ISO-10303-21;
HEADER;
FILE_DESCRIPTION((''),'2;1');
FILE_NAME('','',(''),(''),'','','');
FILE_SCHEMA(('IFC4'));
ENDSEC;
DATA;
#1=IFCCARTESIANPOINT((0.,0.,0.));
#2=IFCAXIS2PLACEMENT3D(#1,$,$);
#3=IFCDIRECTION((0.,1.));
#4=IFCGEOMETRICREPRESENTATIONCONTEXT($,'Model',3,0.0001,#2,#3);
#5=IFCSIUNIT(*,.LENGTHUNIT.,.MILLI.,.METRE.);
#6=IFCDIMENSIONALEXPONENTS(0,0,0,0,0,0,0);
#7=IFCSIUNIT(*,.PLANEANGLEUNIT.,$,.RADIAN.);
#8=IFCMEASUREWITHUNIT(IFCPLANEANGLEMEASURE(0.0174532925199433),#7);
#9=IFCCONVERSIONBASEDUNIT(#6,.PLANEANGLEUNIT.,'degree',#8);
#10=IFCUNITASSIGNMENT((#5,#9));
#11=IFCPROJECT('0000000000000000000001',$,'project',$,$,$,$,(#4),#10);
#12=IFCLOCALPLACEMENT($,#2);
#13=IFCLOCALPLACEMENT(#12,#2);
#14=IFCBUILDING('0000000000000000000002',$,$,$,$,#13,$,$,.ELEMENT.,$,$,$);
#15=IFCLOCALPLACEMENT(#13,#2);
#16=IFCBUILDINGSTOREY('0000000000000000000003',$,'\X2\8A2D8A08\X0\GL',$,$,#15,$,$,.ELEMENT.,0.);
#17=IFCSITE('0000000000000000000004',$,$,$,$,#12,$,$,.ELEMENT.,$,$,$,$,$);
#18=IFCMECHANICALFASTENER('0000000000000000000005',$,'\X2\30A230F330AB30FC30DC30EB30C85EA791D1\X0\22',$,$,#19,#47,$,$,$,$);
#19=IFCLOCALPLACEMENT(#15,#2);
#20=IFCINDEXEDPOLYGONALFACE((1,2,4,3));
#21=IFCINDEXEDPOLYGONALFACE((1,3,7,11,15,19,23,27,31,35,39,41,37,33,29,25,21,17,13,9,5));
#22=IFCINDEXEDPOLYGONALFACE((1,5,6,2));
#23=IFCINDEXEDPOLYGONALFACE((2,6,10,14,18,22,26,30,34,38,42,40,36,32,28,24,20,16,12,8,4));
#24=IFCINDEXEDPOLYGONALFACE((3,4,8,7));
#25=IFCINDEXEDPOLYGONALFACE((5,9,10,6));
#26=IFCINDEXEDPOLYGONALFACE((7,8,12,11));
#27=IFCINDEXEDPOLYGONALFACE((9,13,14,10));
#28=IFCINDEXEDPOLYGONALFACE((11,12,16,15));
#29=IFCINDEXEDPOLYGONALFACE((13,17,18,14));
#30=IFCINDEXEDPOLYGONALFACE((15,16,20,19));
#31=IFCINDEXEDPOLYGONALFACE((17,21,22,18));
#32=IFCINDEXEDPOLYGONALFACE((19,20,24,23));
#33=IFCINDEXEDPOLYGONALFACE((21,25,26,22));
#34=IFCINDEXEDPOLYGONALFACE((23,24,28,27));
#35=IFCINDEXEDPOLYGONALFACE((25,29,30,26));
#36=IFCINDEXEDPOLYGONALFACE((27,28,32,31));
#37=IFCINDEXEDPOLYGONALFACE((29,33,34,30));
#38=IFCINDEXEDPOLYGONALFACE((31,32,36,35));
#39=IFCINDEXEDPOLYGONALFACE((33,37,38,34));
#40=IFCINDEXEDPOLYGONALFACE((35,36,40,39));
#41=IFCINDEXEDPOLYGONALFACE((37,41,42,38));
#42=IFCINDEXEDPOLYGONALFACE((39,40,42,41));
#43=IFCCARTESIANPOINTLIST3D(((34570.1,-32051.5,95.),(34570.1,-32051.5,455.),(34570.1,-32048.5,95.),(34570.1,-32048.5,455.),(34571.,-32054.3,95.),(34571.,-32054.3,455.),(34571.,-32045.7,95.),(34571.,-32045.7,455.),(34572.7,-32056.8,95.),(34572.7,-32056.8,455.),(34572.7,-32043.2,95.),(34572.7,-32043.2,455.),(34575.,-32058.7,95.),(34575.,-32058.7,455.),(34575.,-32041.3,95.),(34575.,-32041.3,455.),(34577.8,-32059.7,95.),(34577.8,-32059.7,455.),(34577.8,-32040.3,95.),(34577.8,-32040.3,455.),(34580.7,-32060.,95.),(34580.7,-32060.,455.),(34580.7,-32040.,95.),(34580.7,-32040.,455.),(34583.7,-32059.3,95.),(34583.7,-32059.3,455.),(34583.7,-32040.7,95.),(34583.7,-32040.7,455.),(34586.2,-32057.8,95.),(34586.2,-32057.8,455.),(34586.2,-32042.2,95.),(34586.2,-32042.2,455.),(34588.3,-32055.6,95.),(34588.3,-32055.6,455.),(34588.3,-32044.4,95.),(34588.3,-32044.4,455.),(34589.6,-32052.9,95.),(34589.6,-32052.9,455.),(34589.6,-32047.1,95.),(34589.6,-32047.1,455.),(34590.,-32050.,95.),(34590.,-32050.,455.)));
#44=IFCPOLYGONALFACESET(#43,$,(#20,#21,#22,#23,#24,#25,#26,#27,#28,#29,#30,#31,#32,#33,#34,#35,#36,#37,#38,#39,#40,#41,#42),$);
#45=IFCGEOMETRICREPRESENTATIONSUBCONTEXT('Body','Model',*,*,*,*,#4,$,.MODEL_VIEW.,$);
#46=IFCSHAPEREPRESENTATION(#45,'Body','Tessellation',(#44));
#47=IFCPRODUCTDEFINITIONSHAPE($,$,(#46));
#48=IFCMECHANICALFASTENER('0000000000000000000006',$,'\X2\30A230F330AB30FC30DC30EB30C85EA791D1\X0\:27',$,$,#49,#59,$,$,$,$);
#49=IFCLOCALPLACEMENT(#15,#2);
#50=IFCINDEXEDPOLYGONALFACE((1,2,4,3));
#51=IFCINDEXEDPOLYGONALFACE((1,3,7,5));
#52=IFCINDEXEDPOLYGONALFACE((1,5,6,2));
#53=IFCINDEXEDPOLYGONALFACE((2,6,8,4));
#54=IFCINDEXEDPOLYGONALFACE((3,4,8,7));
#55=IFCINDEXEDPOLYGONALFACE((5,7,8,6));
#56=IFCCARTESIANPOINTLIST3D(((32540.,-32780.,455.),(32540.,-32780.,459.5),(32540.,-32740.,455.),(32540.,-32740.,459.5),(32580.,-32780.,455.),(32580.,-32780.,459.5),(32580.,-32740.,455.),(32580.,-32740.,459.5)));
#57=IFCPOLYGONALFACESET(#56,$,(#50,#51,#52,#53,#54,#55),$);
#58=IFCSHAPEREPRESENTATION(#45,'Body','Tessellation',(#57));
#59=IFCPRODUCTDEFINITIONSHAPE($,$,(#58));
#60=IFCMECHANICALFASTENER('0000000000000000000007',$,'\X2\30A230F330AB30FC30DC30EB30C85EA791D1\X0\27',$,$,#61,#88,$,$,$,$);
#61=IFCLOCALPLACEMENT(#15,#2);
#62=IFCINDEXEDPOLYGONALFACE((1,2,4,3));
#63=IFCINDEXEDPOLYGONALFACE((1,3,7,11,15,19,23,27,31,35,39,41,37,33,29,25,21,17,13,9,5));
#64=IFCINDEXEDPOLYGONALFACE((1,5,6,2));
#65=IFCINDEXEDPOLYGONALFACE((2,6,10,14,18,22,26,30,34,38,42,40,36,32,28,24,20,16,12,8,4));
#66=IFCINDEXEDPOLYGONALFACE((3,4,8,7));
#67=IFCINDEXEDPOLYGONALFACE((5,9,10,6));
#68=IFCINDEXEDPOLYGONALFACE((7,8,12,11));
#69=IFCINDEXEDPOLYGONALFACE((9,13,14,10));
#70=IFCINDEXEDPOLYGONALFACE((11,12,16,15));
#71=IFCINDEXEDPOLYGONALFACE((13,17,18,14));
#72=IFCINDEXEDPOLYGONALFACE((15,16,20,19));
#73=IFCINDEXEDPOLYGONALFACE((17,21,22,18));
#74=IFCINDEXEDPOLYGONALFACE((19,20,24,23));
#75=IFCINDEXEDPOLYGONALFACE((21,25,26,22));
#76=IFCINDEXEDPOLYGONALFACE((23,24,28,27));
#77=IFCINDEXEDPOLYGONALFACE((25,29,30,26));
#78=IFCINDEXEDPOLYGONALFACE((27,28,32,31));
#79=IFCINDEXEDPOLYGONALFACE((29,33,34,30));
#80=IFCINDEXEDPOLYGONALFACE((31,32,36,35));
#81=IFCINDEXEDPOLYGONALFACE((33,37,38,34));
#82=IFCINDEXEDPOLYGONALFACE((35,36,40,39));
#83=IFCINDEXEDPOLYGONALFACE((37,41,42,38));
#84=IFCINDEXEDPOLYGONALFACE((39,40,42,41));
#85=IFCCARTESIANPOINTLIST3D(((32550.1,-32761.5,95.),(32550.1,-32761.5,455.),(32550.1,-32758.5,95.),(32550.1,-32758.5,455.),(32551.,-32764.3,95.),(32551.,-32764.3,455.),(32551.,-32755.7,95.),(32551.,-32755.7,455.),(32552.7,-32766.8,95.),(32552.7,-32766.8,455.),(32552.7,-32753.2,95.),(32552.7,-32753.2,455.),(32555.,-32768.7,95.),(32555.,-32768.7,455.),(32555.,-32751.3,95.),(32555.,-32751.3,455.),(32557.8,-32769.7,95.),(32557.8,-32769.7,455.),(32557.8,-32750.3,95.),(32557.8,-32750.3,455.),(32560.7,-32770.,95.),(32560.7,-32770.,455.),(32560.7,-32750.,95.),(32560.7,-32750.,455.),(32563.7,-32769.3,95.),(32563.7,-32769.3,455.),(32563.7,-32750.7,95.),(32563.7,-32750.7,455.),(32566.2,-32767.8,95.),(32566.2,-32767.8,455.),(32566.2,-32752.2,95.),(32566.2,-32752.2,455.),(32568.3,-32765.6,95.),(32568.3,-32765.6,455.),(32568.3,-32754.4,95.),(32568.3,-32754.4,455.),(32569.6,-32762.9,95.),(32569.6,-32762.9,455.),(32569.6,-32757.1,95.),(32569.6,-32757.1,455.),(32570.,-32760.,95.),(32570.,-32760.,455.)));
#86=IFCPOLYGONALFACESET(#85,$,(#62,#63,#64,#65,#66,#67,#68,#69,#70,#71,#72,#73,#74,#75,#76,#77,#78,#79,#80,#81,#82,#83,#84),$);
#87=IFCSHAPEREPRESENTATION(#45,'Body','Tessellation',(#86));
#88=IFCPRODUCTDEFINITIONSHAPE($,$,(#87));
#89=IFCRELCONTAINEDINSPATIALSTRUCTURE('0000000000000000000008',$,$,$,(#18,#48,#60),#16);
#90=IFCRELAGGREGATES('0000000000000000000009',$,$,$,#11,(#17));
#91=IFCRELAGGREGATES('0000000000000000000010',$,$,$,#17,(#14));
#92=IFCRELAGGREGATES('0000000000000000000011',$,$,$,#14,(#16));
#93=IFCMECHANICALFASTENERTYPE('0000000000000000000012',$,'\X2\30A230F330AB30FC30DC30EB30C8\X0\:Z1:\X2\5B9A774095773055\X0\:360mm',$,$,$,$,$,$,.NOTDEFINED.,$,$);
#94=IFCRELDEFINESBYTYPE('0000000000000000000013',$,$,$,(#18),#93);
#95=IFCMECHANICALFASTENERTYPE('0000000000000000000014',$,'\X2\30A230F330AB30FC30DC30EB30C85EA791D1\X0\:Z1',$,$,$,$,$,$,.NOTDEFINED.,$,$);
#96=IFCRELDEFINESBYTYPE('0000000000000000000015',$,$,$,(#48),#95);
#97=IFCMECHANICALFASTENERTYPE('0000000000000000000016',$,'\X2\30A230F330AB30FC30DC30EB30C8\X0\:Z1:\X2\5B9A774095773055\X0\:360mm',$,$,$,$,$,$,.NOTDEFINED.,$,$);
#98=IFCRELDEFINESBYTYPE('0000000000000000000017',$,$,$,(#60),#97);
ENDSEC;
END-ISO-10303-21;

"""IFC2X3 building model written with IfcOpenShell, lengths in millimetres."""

from ifc_helpers import new_model, entity, si_unit, converted_unit, direction, frame, origin, origin_with_axes, origin_2d, place, context, subcontext, project, spatial, rectangle, circle, extrude, type_object, element, save


model = new_model("IFC2X3")

# Units and contexts
model_context = context("Model", 3, precision=0.0001, world=origin(), true_north=direction((0.0, 1.0)))
body_context = subcontext(model_context, "Body", "Model", "MODEL_VIEW")
ifc_project = project(units=[si_unit("LENGTHUNIT", "METRE", prefix="MILLI"), converted_unit("PLANEANGLEUNIT", "degree", entity("IfcPlaneAngleMeasure", 0.0174532925199433), si_unit("PLANEANGLEUNIT", "RADIAN"), dimensions=[0, 0, 0, 0, 0, 0, 0])], contexts=[model_context])

# Site, building, storey
site_placement = place(None, origin())
site = spatial("IfcSite", under=ifc_project, at=site_placement, CompositionType="ELEMENT")
building_placement = place(site_placement, origin())
building = spatial("IfcBuilding", under=site, at=building_placement, CompositionType="ELEMENT")
storey_placement = place(building_placement, origin())
storey = spatial("IfcBuildingStorey", under=building, at=storey_placement, Name="設計GL", CompositionType="ELEMENT", Elevation=0.0)

# Mechanical fasteners
mechanical_fastener_type_1 = type_object("IfcMechanicalFastenerType", Name="アンカーボルト:Z1:定着長さ:360mm")
mechanical_fastener_1_placement = place(storey_placement, frame((34580.0, -32050.0, 95.0)))
element("IfcMechanicalFastener", 1, at=mechanical_fastener_1_placement, inside=storey, type_object=mechanical_fastener_type_1, Name="アンカーボルト座金22", context=body_context, shape_type="SweptSolid", body=[
    extrude(circle(Radius=10.0, at=origin_2d()), origin_with_axes(), (0.0, 0.0, 1.0), 360.0),
])
mechanical_fastener_type_2 = type_object("IfcMechanicalFastenerType", Name="アンカーボルト座金:Z1")
mechanical_fastener_2_placement = place(storey_placement, frame((32560.0, -32760.0, 455.0)))
element("IfcMechanicalFastener", 2, at=mechanical_fastener_2_placement, inside=storey, type_object=mechanical_fastener_type_2, Name="アンカーボルト座金:27", context=body_context, shape_type="SweptSolid", body=[
    extrude(rectangle(XDim=40.0, YDim=40.0, at=origin_2d()), origin_with_axes(), (0.0, 0.0, 1.0), 4.5),
])
mechanical_fastener_type_3 = type_object("IfcMechanicalFastenerType", Name="アンカーボルト:Z1:定着長さ:360mm")
mechanical_fastener_3_placement = place(storey_placement, frame((32560.0, -32760.0, 95.0)))
element("IfcMechanicalFastener", 3, at=mechanical_fastener_3_placement, inside=storey, type_object=mechanical_fastener_type_3, Name="アンカーボルト座金27", context=body_context, shape_type="SweptSolid", body=[
    extrude(circle(Radius=10.0, at=origin_2d()), origin_with_axes(), (0.0, 0.0, 1.0), 360.0),
])

save(model, "model.ifc")
